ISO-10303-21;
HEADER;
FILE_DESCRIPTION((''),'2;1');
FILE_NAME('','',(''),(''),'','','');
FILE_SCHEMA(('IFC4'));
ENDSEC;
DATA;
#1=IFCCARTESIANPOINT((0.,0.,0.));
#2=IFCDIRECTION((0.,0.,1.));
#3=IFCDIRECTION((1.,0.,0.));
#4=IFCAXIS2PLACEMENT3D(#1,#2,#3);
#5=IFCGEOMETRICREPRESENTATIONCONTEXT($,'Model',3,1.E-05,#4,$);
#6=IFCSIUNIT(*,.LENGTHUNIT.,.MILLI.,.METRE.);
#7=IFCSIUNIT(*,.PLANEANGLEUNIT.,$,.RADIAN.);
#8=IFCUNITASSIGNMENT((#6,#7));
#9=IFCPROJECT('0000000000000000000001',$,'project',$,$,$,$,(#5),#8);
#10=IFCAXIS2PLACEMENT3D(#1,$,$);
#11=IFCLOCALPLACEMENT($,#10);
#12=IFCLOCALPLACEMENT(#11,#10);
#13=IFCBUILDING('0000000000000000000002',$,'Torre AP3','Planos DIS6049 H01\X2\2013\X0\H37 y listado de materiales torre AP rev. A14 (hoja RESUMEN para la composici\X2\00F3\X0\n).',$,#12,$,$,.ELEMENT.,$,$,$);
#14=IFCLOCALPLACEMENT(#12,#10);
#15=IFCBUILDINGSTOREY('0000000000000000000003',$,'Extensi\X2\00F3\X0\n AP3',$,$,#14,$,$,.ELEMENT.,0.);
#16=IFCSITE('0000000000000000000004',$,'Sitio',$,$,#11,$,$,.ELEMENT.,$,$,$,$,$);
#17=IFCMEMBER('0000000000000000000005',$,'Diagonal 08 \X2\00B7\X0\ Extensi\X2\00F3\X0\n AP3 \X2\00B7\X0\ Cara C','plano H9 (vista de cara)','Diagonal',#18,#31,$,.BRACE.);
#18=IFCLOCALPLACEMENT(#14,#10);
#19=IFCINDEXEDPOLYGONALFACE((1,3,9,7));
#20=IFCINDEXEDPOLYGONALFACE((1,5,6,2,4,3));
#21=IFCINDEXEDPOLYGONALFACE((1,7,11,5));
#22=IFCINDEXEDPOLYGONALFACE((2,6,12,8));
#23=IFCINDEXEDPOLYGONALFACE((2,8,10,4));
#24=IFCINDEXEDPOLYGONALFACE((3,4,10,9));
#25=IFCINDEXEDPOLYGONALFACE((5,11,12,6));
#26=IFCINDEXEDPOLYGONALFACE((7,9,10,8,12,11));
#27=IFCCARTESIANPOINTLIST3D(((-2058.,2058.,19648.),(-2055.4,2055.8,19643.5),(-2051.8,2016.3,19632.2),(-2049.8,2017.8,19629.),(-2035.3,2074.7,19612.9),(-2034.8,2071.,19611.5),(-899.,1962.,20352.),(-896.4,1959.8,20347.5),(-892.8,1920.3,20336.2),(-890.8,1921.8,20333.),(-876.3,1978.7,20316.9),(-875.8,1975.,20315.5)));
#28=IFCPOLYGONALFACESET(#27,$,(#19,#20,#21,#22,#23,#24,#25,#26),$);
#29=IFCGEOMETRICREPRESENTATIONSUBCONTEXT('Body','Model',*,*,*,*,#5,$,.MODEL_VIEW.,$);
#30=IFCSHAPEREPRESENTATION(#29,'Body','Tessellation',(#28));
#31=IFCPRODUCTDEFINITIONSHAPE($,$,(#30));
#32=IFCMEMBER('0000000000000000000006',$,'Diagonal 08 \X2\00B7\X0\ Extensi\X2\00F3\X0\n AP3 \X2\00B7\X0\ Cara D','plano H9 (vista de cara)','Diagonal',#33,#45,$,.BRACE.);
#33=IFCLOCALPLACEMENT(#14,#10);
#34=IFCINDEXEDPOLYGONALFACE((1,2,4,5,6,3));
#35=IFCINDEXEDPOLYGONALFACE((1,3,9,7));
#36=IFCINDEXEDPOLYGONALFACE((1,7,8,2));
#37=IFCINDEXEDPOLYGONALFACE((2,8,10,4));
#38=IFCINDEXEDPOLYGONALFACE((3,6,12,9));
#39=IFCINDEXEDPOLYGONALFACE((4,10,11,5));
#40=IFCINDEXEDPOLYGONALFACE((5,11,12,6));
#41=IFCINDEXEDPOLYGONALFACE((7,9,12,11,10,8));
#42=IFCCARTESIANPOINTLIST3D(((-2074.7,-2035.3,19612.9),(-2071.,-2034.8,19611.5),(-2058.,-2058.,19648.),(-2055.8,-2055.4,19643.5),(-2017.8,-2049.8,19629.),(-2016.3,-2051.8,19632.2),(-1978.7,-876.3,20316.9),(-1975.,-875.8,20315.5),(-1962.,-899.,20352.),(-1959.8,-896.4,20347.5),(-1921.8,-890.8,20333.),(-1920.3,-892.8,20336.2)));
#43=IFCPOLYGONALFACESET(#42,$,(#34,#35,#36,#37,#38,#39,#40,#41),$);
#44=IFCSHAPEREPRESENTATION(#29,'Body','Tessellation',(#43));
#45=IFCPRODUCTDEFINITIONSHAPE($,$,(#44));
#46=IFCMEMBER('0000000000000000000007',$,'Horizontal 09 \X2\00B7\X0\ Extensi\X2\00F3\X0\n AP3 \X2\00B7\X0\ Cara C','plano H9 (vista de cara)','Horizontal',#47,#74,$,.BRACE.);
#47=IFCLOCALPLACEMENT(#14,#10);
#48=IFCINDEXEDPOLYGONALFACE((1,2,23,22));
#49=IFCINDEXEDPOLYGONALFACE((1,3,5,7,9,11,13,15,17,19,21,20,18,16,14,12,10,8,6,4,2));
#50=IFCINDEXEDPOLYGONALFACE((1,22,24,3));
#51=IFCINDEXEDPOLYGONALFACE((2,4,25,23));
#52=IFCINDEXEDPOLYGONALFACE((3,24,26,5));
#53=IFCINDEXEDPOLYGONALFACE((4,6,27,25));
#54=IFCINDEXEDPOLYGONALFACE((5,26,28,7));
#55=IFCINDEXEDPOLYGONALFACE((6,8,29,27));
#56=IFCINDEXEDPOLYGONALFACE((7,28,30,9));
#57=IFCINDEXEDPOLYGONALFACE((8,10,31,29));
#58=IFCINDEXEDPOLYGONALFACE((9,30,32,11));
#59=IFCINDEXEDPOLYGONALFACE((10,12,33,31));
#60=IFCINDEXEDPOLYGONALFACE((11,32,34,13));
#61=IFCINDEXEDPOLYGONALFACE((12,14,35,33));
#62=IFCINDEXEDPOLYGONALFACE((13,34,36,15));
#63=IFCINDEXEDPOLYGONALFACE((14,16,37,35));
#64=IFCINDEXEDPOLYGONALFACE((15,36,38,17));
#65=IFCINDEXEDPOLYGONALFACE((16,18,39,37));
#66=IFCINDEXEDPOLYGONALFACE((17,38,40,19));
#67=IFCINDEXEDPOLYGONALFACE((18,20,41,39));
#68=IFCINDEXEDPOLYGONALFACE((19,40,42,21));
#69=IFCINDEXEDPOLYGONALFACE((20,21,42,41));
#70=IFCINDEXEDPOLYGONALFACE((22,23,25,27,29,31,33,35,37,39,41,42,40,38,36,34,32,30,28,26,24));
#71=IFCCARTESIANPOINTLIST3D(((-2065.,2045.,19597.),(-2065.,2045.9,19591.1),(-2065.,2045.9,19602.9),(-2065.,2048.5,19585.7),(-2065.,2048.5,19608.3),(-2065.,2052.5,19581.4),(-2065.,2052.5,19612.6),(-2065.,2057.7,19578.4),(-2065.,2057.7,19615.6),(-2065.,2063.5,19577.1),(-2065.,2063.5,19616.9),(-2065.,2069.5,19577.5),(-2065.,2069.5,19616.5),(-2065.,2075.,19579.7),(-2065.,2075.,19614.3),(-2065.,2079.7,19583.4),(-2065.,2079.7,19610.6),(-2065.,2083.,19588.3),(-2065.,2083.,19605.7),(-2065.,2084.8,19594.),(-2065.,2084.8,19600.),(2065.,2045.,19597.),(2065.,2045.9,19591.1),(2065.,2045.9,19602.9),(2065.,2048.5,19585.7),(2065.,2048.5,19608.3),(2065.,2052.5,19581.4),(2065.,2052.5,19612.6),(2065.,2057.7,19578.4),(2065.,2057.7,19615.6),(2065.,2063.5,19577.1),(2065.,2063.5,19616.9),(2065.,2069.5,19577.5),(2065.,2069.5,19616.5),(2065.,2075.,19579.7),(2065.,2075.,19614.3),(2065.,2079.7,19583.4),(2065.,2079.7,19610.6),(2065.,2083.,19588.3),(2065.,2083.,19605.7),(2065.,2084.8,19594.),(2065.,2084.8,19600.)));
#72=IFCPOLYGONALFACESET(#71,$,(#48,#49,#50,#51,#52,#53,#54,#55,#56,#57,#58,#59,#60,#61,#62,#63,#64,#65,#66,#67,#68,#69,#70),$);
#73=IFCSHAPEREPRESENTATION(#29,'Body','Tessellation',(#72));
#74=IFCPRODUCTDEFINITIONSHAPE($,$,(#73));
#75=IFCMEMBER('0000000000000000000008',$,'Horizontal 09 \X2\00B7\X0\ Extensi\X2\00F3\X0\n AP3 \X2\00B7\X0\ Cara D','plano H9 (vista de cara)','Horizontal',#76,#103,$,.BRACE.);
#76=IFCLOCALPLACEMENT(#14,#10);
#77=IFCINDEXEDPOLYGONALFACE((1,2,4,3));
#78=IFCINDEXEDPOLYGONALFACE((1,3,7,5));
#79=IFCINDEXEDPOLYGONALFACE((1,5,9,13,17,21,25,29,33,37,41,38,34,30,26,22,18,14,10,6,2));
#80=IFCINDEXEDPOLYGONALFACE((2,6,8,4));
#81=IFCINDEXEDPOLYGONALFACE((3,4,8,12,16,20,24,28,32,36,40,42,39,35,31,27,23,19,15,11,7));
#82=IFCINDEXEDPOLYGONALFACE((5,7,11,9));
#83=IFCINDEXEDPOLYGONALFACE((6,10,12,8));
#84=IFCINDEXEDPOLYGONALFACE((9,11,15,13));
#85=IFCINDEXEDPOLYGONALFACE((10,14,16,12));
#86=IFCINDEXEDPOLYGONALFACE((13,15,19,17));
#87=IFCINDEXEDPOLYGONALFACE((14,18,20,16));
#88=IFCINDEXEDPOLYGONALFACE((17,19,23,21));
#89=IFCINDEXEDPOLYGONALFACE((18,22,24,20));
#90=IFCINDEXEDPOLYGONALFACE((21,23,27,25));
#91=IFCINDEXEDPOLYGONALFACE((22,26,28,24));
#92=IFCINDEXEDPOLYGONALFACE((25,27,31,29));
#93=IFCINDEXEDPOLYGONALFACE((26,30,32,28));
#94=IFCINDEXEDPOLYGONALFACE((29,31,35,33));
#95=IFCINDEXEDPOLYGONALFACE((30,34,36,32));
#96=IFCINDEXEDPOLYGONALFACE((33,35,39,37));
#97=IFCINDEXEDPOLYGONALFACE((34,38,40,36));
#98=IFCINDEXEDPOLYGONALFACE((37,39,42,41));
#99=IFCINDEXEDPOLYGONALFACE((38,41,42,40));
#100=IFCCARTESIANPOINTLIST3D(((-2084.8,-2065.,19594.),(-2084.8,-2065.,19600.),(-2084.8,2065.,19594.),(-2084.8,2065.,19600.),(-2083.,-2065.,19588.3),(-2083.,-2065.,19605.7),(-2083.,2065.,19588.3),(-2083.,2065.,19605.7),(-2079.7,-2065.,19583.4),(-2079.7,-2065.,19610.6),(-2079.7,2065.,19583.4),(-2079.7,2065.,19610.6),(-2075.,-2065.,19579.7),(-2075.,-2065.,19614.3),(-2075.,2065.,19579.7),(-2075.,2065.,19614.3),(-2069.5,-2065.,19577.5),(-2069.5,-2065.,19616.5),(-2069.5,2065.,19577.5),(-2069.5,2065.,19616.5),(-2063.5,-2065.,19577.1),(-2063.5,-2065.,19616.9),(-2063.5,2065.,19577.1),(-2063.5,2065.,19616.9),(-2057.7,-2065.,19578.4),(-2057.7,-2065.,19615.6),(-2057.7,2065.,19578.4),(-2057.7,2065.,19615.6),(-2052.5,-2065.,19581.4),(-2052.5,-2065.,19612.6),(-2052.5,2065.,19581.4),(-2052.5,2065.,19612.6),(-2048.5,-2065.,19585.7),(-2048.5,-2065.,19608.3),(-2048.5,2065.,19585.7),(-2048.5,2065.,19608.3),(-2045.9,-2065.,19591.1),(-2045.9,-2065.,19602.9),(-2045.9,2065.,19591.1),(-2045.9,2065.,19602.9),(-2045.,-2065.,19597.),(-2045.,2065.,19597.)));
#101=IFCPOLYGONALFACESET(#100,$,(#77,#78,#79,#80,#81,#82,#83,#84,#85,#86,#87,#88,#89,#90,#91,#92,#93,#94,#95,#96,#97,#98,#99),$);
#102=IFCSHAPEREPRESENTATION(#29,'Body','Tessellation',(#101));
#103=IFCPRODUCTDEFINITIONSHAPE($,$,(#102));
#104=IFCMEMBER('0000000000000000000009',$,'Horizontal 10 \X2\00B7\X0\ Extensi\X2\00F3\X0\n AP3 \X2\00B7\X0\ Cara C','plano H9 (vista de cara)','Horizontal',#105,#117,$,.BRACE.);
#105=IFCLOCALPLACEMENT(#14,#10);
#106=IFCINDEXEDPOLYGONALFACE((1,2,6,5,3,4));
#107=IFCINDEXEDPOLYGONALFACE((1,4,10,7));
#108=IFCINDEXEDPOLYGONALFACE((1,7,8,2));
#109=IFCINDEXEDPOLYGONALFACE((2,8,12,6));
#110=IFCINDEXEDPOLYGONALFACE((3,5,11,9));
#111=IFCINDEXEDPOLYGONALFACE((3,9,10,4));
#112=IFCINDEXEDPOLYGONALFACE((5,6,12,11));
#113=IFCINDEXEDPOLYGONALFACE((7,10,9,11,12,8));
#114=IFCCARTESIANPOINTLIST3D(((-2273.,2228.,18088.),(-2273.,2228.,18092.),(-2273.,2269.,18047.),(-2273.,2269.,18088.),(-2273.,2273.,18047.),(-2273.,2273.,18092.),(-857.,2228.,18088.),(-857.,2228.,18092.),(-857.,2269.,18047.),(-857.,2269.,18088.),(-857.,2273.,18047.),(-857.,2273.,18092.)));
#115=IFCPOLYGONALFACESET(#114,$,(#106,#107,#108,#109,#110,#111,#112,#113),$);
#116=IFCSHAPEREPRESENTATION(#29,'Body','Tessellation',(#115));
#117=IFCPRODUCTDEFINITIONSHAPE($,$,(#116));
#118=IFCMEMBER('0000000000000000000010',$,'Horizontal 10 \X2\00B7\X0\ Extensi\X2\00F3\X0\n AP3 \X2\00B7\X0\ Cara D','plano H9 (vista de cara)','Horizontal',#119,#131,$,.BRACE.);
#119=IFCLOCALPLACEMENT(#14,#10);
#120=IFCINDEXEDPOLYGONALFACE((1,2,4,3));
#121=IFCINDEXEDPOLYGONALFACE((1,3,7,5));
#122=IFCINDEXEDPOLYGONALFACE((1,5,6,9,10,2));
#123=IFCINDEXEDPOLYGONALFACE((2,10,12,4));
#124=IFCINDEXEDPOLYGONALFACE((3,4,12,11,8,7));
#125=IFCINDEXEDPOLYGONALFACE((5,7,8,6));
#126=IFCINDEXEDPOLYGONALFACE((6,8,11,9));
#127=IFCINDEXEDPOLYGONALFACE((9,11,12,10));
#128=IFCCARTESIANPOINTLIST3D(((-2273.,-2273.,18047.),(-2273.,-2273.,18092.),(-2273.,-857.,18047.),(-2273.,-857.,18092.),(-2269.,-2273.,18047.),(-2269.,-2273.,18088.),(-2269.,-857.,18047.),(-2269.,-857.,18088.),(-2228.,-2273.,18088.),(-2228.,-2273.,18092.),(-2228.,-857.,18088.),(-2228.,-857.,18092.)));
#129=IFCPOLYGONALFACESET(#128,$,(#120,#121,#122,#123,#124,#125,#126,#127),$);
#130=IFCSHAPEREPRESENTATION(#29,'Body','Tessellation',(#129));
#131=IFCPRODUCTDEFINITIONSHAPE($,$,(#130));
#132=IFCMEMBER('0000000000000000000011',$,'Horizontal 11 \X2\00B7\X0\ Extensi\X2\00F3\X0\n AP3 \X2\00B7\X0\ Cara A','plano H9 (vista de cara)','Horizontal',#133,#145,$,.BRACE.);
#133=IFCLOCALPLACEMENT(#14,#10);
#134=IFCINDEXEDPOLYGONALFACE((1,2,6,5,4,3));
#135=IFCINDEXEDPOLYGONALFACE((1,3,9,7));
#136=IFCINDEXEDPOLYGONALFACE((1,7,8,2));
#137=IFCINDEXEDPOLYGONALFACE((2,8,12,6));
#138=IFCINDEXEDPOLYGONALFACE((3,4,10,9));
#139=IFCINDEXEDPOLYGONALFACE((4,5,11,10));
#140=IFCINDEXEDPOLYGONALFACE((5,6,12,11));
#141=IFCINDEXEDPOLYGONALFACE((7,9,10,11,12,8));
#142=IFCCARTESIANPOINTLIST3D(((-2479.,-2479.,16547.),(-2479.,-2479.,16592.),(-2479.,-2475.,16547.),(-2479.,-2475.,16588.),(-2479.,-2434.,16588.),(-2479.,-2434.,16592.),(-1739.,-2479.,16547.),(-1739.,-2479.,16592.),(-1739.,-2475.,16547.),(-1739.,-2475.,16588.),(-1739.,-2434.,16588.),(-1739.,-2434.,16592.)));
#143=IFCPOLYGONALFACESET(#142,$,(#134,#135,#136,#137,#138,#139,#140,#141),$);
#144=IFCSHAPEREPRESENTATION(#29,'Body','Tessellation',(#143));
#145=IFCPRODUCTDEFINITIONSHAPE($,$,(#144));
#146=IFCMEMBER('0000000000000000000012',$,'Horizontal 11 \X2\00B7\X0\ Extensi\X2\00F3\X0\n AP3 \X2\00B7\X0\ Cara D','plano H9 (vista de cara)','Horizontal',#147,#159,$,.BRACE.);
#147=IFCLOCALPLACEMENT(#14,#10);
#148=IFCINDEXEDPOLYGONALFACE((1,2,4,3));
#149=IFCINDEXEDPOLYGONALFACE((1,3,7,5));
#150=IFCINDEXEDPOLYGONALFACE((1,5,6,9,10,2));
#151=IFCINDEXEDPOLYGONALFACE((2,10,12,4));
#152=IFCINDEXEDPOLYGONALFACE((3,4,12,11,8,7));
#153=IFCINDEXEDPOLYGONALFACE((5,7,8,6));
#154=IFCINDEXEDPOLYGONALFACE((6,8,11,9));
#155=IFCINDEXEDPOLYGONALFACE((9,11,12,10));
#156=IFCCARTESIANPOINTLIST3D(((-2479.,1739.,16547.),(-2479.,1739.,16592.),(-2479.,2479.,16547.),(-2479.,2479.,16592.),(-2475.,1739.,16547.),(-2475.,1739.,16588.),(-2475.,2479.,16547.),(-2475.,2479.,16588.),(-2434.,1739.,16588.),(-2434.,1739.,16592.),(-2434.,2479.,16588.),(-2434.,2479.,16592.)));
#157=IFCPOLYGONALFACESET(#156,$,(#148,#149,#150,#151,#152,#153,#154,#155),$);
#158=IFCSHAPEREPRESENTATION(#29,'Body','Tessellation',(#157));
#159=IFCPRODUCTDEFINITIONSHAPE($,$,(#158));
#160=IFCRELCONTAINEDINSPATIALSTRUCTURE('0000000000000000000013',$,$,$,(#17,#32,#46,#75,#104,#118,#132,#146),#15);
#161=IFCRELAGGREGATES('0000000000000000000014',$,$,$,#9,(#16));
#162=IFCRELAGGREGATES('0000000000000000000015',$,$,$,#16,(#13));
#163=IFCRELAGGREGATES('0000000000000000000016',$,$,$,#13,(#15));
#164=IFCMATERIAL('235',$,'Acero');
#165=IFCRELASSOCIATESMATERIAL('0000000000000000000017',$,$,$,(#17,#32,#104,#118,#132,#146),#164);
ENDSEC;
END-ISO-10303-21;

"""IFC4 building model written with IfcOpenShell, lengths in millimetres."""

from ifc_helpers import new_model, si_unit, frame, frame_2d, origin, origin_with_axes, place, context, subcontext, project, spatial, circle, l_section, extrude, material, element, save


model = new_model("IFC4")

# Units and contexts
model_context = context("Model", 3, precision=1e-05, world=origin_with_axes())
body_context = subcontext(model_context, "Body", "Model", "MODEL_VIEW")
ifc_project = project(units=[si_unit("LENGTHUNIT", "METRE", prefix="MILLI"), si_unit("PLANEANGLEUNIT", "RADIAN")], contexts=[model_context])

# Site, building, storey
site_placement = place(None, origin())
site = spatial("IfcSite", under=ifc_project, at=site_placement, Name="Sitio", CompositionType="ELEMENT")
building_placement = place(site_placement, origin())
building = spatial("IfcBuilding", under=site, at=building_placement, Name="Torre AP3", Description="Planos DIS6049 H01–H37 y listado de materiales torre AP rev. A14 (hoja RESUMEN para la composición).", CompositionType="ELEMENT")
storey_placement = place(building_placement, origin())
storey = spatial("IfcBuildingStorey", under=building, at=storey_placement, Name="Extensión AP3", CompositionType="ELEMENT", Elevation=0.0)

# Members
ifc_material_1 = material(Name="235", Category="Acero")
for number, where, z_axis, x_axis, name in (
    (1, (-2058.0, 2058.0, 19648.0), (0.852549, -0.070617, 0.517855), (0.137057, -0.925948, -0.351904), "Diagonal 08 · Extensión AP3 · Cara C"),
    (2, (-2058.0, -2058.0, 19648.0), (0.070617, 0.852549, 0.517855), (0.925948, 0.137057, -0.351904), "Diagonal 08 · Extensión AP3 · Cara D"),
):
    element("IfcMember", number, at=place(storey_placement, frame(where, z_axis=z_axis, x_axis=x_axis)), inside=storey, material=ifc_material_1, Name=name, Description="plano H9 (vista de cara)", ObjectType="Diagonal", PredefinedType="BRACE", context=body_context, shape_type="SweptSolid", body=[
        extrude(l_section(Depth=45.0, Width=45.0, Thickness=4.0, at=frame_2d((22.5, 22.5))), None, (0.0, 0.0, 1.0), 1359.5),
    ])
for number, where, z_axis, x_axis, name in (
    (3, (-2065.0, 2065.0, 19597.0), (1.0, 0.0, 0.0), (0.0, -1.0, 0.0), "Horizontal 09 · Extensión AP3 · Cara C"),
    (4, (-2065.0, -2065.0, 19597.0), (0.0, 1.0, 0.0), (1.0, 0.0, 0.0), "Horizontal 09 · Extensión AP3 · Cara D"),
):
    element("IfcMember", number, at=place(storey_placement, frame(where, z_axis=z_axis, x_axis=x_axis)), inside=storey, Name=name, Description="plano H9 (vista de cara)", ObjectType="Horizontal", PredefinedType="BRACE", context=body_context, shape_type="SweptSolid", body=[
        extrude(circle(Radius=20.0), None, (0.0, 0.0, 1.0), 4130.0),
    ])
for number, where, z_axis, x_axis, name in (
    (5, (-2273.0, 2273.0, 18092.0), (1.0, 0.0, 0.0), (0.0, -1.0, 0.0), "Horizontal 10 · Extensión AP3 · Cara C"),
    (6, (-2273.0, -2273.0, 18092.0), (0.0, 1.0, 0.0), (1.0, 0.0, 0.0), "Horizontal 10 · Extensión AP3 · Cara D"),
):
    element("IfcMember", number, at=place(storey_placement, frame(where, z_axis=z_axis, x_axis=x_axis)), inside=storey, material=ifc_material_1, Name=name, Description="plano H9 (vista de cara)", ObjectType="Horizontal", PredefinedType="BRACE", context=body_context, shape_type="SweptSolid", body=[
        extrude(l_section(Depth=45.0, Width=45.0, Thickness=4.0, at=frame_2d((22.5, 22.5))), None, (0.0, 0.0, 1.0), 1416.0),
    ])
for number, where, z_axis, x_axis, name in (
    (7, (-1739.0, -2479.0, 16592.0), (-1.0, 0.0, 0.0), (0.0, 1.0, 0.0), "Horizontal 11 · Extensión AP3 · Cara A"),
    (8, (-2479.0, 1739.0, 16592.0), (0.0, 1.0, 0.0), (1.0, 0.0, 0.0), "Horizontal 11 · Extensión AP3 · Cara D"),
):
    element("IfcMember", number, at=place(storey_placement, frame(where, z_axis=z_axis, x_axis=x_axis)), inside=storey, material=ifc_material_1, Name=name, Description="plano H9 (vista de cara)", ObjectType="Horizontal", PredefinedType="BRACE", context=body_context, shape_type="SweptSolid", body=[
        extrude(l_section(Depth=45.0, Width=45.0, Thickness=4.0, at=frame_2d((22.5, 22.5))), None, (0.0, 0.0, 1.0), 740.0),
    ])

save(model, "model.ifc")
